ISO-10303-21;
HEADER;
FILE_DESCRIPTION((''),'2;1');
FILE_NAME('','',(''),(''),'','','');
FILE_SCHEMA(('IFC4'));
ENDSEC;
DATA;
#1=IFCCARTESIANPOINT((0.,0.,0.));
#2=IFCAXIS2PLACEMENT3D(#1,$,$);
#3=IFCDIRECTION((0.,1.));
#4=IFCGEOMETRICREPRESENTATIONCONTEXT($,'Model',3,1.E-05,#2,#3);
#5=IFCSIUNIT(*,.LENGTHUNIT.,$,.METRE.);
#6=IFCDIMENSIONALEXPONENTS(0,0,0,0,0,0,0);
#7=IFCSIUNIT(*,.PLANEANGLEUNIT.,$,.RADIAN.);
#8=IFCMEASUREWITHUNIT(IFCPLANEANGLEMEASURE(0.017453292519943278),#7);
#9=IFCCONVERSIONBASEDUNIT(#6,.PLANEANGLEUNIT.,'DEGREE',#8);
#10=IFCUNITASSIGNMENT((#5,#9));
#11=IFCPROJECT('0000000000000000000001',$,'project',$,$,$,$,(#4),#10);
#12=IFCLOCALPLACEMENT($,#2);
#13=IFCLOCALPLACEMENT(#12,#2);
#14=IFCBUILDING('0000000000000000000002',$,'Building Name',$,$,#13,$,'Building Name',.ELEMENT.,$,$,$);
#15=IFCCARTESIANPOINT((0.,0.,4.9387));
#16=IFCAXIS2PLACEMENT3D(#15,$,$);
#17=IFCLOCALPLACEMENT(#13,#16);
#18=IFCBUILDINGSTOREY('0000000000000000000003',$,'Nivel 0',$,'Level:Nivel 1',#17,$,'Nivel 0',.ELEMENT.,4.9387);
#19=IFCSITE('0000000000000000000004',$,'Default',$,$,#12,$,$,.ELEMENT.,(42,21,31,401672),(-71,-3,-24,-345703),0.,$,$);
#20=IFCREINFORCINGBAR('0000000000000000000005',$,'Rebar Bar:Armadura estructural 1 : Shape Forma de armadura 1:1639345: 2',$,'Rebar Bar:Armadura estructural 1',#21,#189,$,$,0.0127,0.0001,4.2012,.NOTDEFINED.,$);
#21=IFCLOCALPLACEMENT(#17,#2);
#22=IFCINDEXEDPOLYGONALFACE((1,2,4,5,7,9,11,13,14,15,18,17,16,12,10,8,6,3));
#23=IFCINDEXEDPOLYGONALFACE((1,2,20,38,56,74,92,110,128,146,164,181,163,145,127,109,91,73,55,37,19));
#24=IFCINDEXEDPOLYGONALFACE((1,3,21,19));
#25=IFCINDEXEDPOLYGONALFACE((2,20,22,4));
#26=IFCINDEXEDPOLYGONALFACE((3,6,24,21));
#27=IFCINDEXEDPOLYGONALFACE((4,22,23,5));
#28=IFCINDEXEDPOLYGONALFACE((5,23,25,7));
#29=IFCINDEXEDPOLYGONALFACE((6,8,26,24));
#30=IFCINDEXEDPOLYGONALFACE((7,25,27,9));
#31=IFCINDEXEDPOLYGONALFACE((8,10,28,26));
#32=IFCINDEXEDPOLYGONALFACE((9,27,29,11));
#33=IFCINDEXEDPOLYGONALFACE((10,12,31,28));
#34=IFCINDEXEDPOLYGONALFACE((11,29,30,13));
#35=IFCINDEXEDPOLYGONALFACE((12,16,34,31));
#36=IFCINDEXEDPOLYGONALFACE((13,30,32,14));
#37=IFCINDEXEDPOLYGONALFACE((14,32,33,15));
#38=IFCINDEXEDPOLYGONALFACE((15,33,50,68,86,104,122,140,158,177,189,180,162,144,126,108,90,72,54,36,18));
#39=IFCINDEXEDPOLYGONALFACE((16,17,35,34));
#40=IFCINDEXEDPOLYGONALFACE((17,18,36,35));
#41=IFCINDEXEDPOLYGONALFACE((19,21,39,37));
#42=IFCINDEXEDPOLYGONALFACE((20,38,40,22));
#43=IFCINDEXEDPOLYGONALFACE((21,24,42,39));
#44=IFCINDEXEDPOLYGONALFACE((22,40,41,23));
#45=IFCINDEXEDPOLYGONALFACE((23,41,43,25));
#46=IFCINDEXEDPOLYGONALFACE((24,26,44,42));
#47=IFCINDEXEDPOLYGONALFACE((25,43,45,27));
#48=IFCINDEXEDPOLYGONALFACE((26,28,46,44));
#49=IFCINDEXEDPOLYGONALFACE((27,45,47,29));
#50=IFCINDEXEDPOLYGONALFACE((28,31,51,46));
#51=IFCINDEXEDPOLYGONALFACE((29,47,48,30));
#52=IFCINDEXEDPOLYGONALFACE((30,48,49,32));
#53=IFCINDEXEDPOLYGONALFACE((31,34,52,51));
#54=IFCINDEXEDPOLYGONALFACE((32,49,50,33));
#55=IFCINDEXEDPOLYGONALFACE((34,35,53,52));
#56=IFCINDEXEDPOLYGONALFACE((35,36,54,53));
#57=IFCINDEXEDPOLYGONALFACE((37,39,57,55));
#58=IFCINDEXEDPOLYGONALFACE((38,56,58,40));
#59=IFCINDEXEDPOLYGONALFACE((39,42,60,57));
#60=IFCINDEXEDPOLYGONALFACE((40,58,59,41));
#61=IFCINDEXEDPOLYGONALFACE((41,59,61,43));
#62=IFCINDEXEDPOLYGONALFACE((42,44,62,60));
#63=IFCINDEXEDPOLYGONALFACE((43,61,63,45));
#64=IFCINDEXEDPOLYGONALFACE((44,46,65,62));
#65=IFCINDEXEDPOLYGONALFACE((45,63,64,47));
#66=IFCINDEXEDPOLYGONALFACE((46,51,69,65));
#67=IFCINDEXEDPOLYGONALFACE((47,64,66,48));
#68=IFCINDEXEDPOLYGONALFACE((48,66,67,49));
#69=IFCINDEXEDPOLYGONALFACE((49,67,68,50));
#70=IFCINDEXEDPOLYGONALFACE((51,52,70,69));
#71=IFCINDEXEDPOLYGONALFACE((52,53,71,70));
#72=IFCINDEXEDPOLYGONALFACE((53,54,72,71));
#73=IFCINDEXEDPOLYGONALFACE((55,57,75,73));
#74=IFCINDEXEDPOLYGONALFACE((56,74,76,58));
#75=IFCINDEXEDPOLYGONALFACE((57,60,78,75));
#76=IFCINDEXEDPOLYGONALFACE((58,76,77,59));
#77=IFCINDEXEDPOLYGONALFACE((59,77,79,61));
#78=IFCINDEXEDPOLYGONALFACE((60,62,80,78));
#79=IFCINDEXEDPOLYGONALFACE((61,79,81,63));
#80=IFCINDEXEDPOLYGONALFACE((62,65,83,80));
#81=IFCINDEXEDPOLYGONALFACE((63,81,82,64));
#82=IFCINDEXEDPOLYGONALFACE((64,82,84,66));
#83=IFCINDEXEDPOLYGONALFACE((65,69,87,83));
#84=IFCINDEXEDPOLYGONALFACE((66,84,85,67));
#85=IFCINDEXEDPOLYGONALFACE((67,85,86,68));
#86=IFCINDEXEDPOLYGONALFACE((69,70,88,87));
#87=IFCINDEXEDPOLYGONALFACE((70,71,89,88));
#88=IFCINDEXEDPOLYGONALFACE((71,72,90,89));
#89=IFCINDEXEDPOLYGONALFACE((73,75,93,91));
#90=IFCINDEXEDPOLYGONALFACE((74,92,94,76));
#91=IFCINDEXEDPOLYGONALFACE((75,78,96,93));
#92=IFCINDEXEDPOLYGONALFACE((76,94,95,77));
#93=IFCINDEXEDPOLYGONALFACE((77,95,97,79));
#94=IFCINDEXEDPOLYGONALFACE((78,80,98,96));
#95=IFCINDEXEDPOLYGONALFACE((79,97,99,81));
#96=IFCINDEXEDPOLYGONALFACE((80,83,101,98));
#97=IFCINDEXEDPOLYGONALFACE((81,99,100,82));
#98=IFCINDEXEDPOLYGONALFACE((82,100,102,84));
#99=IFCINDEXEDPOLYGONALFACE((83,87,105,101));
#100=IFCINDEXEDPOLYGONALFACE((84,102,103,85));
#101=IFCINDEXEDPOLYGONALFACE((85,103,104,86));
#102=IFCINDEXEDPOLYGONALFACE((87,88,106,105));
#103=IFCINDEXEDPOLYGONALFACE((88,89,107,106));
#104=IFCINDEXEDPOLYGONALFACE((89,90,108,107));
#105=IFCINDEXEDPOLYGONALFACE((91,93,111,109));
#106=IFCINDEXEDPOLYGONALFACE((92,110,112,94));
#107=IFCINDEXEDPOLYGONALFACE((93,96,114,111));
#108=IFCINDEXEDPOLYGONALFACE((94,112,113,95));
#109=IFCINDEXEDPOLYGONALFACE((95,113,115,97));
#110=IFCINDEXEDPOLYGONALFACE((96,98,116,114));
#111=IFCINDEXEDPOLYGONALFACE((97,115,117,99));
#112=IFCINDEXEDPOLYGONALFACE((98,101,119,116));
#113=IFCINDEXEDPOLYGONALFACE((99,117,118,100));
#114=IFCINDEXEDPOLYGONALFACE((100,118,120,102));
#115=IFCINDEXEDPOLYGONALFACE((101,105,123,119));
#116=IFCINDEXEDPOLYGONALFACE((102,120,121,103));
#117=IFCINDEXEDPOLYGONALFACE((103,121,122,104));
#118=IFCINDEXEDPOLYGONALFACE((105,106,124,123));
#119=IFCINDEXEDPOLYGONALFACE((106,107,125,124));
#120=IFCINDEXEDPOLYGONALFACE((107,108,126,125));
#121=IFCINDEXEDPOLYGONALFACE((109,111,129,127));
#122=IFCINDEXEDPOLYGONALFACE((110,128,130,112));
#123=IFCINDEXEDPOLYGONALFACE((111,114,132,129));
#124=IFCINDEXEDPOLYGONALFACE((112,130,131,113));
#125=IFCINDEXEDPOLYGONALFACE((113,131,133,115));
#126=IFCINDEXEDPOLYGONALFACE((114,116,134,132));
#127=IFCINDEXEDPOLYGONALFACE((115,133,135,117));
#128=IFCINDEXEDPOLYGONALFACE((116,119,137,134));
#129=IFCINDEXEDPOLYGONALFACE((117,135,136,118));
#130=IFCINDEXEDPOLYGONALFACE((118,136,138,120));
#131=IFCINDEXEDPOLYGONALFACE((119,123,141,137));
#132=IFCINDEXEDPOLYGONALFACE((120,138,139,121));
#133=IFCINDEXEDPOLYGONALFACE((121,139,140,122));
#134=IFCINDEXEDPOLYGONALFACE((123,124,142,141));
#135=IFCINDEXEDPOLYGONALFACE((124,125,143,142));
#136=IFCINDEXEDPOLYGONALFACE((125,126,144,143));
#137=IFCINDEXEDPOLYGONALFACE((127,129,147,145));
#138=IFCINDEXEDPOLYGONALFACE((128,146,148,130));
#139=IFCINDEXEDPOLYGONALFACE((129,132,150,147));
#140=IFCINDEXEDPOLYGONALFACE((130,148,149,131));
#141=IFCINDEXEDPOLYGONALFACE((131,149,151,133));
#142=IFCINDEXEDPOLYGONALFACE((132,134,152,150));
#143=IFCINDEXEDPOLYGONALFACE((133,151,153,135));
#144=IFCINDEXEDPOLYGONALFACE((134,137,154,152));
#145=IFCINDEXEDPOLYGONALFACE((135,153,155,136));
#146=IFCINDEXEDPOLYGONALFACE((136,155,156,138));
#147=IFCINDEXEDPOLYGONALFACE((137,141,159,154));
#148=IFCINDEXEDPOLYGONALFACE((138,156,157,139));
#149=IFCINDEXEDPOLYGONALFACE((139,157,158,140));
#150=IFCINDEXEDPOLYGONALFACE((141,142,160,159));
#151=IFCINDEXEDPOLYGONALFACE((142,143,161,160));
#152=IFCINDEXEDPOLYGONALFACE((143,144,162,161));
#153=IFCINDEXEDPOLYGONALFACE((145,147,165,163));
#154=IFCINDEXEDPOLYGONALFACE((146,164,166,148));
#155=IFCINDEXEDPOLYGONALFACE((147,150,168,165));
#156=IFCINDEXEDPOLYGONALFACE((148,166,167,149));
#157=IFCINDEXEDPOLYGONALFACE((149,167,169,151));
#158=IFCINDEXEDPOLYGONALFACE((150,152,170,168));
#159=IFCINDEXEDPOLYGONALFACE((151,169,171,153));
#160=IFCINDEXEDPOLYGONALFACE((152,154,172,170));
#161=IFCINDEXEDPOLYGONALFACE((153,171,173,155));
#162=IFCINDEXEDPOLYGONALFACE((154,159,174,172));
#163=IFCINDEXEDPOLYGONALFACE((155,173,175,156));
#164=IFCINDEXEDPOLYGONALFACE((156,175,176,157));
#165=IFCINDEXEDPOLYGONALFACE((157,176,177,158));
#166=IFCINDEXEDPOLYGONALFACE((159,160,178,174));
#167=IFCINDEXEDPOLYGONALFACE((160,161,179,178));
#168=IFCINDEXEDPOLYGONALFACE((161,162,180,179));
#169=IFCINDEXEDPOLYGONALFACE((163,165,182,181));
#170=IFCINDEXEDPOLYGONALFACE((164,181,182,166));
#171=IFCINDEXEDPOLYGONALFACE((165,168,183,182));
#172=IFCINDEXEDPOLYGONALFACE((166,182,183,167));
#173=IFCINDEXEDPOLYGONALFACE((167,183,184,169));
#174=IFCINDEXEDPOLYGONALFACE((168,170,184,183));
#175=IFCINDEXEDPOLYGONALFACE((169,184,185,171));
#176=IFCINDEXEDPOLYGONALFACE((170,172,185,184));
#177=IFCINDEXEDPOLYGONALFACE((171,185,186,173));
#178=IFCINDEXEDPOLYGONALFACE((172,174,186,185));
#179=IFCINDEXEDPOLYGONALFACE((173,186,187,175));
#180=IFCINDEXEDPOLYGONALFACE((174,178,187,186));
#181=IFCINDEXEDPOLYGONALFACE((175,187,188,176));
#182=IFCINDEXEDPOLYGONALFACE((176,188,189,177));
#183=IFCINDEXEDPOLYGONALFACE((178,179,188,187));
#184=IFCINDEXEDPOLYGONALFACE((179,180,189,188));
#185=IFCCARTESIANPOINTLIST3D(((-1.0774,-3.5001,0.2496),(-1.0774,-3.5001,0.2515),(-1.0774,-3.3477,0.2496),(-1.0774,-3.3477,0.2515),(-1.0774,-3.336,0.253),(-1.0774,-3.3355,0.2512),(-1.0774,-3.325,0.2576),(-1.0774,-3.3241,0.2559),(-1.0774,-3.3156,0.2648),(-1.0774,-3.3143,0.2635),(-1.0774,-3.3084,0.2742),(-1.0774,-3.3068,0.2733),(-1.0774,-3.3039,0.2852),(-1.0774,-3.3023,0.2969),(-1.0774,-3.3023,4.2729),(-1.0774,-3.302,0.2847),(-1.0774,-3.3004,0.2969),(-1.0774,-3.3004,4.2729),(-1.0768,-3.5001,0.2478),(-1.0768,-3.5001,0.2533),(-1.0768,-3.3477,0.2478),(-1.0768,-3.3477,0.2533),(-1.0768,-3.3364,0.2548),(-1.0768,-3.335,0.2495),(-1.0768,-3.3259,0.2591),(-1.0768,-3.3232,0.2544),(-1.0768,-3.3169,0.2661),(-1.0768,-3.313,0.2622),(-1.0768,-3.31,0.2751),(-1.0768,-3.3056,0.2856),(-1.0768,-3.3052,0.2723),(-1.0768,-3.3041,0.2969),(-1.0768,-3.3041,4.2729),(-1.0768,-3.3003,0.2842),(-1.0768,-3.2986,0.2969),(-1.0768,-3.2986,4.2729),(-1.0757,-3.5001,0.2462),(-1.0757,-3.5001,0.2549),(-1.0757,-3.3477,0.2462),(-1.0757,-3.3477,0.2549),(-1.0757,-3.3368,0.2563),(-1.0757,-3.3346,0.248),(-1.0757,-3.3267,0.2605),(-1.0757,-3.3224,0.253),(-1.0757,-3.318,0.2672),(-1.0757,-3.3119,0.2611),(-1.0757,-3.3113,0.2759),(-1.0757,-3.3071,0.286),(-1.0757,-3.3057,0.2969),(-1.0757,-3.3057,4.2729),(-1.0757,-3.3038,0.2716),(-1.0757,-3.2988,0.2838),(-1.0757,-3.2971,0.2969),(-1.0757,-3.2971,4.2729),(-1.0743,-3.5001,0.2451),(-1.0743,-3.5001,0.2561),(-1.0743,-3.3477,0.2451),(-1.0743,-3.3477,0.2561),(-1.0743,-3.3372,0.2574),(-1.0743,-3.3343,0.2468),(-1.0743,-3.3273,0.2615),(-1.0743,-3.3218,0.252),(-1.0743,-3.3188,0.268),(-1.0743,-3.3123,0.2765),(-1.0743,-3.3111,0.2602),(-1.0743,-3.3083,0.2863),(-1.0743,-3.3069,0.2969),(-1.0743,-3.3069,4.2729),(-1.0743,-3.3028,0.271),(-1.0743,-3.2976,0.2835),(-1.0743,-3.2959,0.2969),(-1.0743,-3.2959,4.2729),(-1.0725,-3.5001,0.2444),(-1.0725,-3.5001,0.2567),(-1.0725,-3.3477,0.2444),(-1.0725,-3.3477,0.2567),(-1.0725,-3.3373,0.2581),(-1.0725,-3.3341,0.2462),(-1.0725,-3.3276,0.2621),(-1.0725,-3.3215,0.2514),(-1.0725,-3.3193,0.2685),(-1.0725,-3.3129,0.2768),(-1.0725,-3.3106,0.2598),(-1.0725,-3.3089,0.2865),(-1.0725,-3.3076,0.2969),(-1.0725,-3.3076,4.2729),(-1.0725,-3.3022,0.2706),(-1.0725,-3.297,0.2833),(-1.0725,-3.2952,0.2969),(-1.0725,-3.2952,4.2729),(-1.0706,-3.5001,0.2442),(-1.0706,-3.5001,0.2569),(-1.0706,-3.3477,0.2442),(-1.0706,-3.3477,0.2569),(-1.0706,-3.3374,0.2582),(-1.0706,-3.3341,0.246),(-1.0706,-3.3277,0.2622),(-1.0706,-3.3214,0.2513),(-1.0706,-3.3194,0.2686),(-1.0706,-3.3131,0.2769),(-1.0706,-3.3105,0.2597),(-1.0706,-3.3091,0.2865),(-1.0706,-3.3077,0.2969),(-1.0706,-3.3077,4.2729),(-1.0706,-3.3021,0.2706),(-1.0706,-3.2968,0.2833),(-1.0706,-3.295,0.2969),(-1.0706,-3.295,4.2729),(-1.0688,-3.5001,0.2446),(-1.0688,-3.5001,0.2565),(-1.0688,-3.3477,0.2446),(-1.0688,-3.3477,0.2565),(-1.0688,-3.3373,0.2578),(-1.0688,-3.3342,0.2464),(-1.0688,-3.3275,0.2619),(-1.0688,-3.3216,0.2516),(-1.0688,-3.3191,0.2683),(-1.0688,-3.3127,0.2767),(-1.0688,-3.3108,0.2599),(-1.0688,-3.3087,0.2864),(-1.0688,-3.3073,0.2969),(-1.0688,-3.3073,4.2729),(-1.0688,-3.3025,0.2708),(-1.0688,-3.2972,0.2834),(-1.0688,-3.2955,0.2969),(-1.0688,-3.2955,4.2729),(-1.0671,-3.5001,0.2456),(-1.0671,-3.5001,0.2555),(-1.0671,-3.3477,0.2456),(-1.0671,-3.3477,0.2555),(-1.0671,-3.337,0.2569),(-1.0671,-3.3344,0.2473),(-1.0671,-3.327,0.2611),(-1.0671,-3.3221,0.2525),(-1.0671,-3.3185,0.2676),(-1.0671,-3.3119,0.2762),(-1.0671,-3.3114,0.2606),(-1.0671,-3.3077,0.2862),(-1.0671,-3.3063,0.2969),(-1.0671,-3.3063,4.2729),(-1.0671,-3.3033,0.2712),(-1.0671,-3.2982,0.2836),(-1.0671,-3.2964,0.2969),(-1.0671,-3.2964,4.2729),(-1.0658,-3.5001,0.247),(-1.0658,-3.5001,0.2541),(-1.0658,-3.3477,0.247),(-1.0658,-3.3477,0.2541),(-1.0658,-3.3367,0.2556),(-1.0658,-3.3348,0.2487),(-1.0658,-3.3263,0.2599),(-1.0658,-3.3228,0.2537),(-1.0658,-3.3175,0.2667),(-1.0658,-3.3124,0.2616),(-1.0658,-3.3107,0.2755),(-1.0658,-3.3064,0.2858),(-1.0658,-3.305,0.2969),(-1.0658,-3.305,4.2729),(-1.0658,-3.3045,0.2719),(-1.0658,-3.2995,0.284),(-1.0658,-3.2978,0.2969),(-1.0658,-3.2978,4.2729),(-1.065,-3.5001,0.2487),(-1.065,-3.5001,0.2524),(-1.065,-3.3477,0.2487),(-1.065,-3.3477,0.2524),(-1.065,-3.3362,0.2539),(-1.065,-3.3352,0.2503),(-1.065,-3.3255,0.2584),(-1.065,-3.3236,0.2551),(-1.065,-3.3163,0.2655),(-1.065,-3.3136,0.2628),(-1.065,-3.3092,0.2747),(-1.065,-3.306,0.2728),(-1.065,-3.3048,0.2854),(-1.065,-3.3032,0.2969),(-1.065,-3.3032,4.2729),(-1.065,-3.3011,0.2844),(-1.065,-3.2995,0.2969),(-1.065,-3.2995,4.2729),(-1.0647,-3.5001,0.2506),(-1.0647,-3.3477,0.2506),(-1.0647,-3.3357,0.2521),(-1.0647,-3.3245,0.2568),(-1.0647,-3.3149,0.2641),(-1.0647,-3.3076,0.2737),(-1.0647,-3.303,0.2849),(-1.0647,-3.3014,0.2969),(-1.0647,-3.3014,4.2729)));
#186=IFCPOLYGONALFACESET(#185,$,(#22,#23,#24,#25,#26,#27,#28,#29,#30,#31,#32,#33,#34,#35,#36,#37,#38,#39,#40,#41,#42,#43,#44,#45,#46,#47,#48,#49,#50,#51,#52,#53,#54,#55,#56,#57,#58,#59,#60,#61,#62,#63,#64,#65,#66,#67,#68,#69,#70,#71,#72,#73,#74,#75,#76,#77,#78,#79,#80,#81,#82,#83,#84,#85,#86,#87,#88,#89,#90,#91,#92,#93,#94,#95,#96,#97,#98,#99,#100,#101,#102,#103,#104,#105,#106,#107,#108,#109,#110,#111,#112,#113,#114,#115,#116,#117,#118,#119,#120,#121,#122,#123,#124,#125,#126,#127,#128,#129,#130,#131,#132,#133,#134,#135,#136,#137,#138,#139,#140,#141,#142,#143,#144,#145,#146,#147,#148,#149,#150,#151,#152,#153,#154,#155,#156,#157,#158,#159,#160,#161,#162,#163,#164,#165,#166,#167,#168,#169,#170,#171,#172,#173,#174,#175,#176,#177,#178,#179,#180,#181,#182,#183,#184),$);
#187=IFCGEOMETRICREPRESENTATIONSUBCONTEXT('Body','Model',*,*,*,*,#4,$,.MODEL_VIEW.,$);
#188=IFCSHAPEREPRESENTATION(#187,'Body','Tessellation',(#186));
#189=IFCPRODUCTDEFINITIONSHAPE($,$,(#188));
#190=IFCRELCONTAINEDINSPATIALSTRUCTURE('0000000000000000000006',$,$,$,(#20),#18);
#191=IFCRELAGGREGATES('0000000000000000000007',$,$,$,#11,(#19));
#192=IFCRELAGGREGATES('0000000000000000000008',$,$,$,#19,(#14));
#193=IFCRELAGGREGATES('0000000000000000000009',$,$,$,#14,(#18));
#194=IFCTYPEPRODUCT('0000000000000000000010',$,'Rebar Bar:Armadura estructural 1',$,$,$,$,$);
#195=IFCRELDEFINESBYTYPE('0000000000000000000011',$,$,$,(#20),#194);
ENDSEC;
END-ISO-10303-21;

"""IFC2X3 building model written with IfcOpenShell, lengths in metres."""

from ifc_helpers import new_model, entity, si_unit, converted_unit, direction, frame, origin, place, context, subcontext, project, spatial, type_object, element, save


model = new_model("IFC2X3")

# Units and contexts
model_context = context("Model", 3, precision=1e-05, world=origin(), true_north=direction((0.0, 1.0)))
body_context = subcontext(model_context, "Body", "Model", "MODEL_VIEW")
ifc_project = project(units=[si_unit("LENGTHUNIT", "METRE"), converted_unit("PLANEANGLEUNIT", "DEGREE", entity("IfcPlaneAngleMeasure", 0.017453292519943278), si_unit("PLANEANGLEUNIT", "RADIAN"), dimensions=[0, 0, 0, 0, 0, 0, 0])], contexts=[model_context])

# Site, building, storey
site_placement = place(None, origin())
site = spatial("IfcSite", under=ifc_project, at=site_placement, Name="Default", CompositionType="ELEMENT", RefLatitude=(42, 21, 31, 401672), RefLongitude=(-71, -3, -24, -345703), RefElevation=0.0)
building_placement = place(site_placement, origin())
building = spatial("IfcBuilding", under=site, at=building_placement, Name="Building Name", LongName="Building Name", CompositionType="ELEMENT")
storey_placement = place(building_placement, frame((0.0, 0.0, 4.9387)))
storey = spatial("IfcBuildingStorey", under=building, at=storey_placement, Name="Nivel 0", ObjectType="Level:Nivel 1", LongName="Nivel 0", CompositionType="ELEMENT", Elevation=4.9387)

# Reinforcing bar
type_product = type_object("IfcTypeProduct", Name="Rebar Bar:Armadura estructural 1")
reinforcing_bar_1_placement = place(storey_placement, origin())
element("IfcReinforcingBar", 1, at=reinforcing_bar_1_placement, inside=storey, type_object=type_product, Name="Rebar Bar:Armadura estructural 1 : Shape Forma de armadura 1:1639345: 2", ObjectType="Rebar Bar:Armadura estructural 1", BarLength=4.2012, BarRole="NOTDEFINED", CrossSectionArea=0.0001, NominalDiameter=0.0127, context=body_context, shape_type="AdvancedSweptSolid", body=[
    entity("IfcSweptDiskSolid", entity("IfcCompositeCurve", [entity("IfcCompositeCurveSegment", "CONTINUOUS", True, entity("IfcPolyline", [entity("IfcCartesianPoint", [-1.0711, -3.5001, 0.2506]), entity("IfcCartesianPoint", [-1.0711, -3.3477, 0.2506])])), entity("IfcCompositeCurveSegment", "CONTINUOUS", True, entity("IfcTrimmedCurve", entity("IfcCircle", entity("IfcAxis2Placement3D", entity("IfcCartesianPoint", [-1.0711, -3.3477, 0.2969]), entity("IfcDirection", [1.0, 0.0, 0.0]), entity("IfcDirection", [0.0, 1.0, 0.0])), 0.0464), [entity("IfcParameterValue", 270.0)], [entity("IfcParameterValue", 360.0)], True, "PARAMETER")), entity("IfcCompositeCurveSegment", "CONTINUOUS", True, entity("IfcPolyline", [entity("IfcCartesianPoint", [-1.0711, -3.3014, 0.2969]), entity("IfcCartesianPoint", [-1.0711, -3.3014, 4.2729])]))], False), 0.0063, None, 0.0, 92.0),
])

save(model, "model.ifc")
